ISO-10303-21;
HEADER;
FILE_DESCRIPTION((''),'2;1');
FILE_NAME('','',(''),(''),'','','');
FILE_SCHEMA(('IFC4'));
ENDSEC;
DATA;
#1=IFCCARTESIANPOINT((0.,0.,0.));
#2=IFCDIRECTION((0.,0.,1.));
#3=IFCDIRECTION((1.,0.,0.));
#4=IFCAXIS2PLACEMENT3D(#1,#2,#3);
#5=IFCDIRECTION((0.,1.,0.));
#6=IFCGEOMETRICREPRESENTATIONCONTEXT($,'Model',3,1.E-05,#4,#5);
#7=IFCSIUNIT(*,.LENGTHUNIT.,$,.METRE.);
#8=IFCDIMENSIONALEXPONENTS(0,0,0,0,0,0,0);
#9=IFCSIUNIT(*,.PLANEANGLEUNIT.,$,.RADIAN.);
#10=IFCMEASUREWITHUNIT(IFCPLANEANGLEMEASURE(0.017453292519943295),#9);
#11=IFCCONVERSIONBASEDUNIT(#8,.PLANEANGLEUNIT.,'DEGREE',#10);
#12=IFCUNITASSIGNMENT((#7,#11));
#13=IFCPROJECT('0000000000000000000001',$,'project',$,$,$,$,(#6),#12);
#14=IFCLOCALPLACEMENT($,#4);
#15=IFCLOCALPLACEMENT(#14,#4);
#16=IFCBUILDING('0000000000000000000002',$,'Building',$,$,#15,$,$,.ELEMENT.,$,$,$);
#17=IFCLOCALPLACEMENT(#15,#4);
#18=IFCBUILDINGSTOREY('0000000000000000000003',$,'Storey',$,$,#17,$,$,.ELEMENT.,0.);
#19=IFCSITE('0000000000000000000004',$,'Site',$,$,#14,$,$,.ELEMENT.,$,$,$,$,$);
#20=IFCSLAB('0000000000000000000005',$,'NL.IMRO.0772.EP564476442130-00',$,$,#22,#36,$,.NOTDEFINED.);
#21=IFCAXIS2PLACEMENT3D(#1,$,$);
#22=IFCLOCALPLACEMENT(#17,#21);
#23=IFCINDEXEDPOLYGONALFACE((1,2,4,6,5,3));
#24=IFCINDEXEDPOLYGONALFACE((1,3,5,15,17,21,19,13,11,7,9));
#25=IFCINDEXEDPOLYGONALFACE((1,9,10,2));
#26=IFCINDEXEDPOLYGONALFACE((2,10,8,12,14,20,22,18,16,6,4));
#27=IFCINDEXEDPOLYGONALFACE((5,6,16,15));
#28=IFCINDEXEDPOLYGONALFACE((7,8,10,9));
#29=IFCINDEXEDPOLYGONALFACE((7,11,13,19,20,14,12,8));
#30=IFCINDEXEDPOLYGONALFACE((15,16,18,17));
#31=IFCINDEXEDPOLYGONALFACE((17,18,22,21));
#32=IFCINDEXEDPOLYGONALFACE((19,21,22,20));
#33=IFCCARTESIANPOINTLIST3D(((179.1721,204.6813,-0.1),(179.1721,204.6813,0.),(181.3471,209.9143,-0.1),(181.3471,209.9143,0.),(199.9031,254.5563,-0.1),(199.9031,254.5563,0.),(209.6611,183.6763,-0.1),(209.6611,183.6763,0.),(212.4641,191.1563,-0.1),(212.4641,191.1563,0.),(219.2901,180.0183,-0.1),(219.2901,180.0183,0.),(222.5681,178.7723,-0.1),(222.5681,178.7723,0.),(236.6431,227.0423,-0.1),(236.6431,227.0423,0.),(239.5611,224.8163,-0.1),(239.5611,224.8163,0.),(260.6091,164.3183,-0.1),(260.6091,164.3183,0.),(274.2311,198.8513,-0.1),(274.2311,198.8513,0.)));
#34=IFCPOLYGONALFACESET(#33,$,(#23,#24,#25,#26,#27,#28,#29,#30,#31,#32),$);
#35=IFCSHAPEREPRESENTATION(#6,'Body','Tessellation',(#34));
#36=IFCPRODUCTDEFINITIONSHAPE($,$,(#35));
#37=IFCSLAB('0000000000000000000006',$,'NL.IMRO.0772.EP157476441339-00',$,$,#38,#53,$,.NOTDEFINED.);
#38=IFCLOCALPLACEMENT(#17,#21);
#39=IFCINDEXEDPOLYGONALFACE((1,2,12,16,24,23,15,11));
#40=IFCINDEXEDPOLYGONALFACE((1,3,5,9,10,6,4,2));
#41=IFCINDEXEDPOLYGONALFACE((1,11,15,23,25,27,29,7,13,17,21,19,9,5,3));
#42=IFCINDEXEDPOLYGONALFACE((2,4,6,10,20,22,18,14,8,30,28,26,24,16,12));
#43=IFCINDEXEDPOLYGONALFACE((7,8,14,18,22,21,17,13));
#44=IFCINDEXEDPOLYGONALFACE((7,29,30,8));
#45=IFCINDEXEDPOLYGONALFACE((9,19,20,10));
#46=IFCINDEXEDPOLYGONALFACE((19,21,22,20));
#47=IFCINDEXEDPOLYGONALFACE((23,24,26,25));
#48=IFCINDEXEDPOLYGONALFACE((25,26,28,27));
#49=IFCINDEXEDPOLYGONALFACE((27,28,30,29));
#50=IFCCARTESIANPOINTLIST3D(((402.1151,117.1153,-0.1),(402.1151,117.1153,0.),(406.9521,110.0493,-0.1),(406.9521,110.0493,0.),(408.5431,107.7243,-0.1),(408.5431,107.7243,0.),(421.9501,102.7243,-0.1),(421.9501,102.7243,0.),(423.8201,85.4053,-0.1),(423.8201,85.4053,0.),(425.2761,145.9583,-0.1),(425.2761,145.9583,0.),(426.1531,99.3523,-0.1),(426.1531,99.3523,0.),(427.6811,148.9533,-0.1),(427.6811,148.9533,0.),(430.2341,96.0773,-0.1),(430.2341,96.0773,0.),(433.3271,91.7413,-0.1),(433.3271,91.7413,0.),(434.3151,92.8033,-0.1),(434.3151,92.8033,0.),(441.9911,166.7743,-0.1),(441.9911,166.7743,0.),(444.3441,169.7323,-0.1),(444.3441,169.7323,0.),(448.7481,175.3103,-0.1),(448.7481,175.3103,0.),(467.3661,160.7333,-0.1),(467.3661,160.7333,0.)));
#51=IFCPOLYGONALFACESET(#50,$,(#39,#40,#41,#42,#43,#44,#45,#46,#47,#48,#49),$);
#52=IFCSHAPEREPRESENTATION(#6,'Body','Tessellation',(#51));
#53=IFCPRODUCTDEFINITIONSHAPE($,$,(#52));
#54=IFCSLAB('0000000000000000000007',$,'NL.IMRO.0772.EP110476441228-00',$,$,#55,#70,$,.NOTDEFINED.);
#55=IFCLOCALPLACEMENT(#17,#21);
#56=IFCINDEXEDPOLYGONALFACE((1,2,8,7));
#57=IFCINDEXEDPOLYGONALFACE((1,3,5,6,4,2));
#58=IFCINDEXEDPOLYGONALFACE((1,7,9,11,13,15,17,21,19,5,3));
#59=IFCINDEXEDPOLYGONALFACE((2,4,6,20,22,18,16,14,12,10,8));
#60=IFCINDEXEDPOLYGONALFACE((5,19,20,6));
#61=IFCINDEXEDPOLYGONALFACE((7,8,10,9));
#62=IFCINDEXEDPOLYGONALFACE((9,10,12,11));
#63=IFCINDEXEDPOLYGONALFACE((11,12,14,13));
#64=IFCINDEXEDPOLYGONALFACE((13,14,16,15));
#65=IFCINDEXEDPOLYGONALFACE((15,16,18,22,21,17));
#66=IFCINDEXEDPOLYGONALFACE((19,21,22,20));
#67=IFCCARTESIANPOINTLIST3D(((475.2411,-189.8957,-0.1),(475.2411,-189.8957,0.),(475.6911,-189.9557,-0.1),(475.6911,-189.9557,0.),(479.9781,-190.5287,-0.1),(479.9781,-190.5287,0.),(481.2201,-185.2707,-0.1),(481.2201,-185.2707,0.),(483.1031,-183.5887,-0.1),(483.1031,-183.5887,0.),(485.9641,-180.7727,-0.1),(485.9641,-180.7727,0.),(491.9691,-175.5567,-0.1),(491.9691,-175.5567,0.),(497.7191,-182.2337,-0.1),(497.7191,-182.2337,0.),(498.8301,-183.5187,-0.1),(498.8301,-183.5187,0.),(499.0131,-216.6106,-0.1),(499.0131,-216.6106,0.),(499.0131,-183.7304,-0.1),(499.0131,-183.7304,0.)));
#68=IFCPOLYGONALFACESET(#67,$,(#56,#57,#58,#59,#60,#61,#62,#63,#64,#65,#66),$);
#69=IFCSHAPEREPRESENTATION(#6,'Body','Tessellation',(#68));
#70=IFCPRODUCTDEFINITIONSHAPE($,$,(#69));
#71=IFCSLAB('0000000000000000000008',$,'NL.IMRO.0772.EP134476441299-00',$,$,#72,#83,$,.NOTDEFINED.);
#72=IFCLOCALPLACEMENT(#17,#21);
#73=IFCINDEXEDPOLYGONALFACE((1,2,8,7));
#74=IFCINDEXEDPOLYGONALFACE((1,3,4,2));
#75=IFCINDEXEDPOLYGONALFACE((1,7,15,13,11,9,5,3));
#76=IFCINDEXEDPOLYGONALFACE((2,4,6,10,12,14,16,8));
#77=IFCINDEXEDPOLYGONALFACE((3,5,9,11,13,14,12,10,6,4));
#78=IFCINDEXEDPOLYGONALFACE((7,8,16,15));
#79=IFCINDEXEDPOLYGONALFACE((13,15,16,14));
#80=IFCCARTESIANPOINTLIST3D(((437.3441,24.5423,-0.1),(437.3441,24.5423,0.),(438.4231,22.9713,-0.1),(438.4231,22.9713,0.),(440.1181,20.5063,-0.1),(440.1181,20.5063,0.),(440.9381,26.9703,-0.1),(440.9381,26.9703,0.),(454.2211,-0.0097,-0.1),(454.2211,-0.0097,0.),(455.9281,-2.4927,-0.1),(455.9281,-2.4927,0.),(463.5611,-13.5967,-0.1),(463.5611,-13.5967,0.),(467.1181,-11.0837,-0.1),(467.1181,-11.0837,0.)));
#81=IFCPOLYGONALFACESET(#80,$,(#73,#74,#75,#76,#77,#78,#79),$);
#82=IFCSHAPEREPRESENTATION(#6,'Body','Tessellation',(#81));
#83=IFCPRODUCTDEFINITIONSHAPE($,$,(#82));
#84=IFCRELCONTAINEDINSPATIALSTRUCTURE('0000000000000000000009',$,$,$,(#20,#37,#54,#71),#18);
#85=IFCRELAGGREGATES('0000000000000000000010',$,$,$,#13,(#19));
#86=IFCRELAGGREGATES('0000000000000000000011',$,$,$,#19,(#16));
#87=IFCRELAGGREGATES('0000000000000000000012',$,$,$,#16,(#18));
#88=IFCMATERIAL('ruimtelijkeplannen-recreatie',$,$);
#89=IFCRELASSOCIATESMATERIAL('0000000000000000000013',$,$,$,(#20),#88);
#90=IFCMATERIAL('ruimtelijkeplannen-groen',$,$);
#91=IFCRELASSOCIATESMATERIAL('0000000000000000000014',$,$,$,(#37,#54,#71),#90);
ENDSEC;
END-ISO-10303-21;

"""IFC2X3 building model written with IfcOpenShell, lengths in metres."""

from ifc_helpers import new_model, entity, si_unit, converted_unit, direction, frame, origin_with_axes, place, context, project, spatial, polyline, outline, extrude, material, element, save


model = new_model("IFC2X3")

# Units and contexts
model_context = context("Model", 3, precision=1e-05, world=origin_with_axes(), true_north=direction((0.0, 1.0, 0.0)))
ifc_project = project(units=[si_unit("LENGTHUNIT", "METRE"), converted_unit("PLANEANGLEUNIT", "DEGREE", entity("IfcPlaneAngleMeasure", 0.017453292519943295), si_unit("PLANEANGLEUNIT", "RADIAN"), dimensions=[0, 0, 0, 0, 0, 0, 0])], contexts=[model_context])

# Site, building, storey
site_placement = place(None, origin_with_axes())
site = spatial("IfcSite", under=ifc_project, at=site_placement, Name="Site", CompositionType="ELEMENT")
building_placement = place(site_placement, origin_with_axes())
building = spatial("IfcBuilding", under=site, at=building_placement, Name="Building", CompositionType="ELEMENT")
storey_placement = place(building_placement, origin_with_axes())
storey = spatial("IfcBuildingStorey", under=building, at=storey_placement, Name="Storey", CompositionType="ELEMENT", Elevation=0.0)

# Slabs
ifc_material_1 = material(Name="ruimtelijkeplannen-groen")
ifc_material_2 = material(Name="ruimtelijkeplannen-recreatie")
slab_1_placement = place(storey_placement, frame((0.0, 0.0, -0.1), z_axis=(0.0, 0.0, 1.0), x_axis=(1.0, 0.0, 0.0)))
element("IfcSlab", 1, at=slab_1_placement, inside=storey, material=ifc_material_2, Name="NL.IMRO.0772.EP564476442130-00", PredefinedType="NOTDEFINED", context=model_context, shape_type="SweptSolid", body=[
    extrude(outline(polyline([(236.6431, 227.0423), (239.5611, 224.8163), (274.2311, 198.8513), (260.6091, 164.3183), (222.5681, 178.7723), (219.2901, 180.0183), (209.6611, 183.6763), (212.4641, 191.1563), (179.1721, 204.6813), (181.3471, 209.9143), (199.9031, 254.5563), (236.6431, 227.0423)])), origin_with_axes(), (0.0, 0.0, 1.0), 0.1),
])
slab_2_placement = place(storey_placement, frame((0.0, 0.0, -0.1), z_axis=(0.0, 0.0, 1.0), x_axis=(1.0, 0.0, 0.0)))
element("IfcSlab", 2, at=slab_2_placement, inside=storey, material=ifc_material_1, Name="NL.IMRO.0772.EP157476441339-00", PredefinedType="NOTDEFINED", context=model_context, shape_type="SweptSolid", body=[
    extrude(outline(polyline([(433.3271, 91.7413), (423.8201, 85.4053), (408.5431, 107.7243), (406.9521, 110.0493), (402.1151, 117.1153), (425.2761, 145.9583), (427.6811, 148.9533), (441.9911, 166.7743), (444.3441, 169.7323), (448.7481, 175.3103), (467.3661, 160.7333), (421.9501, 102.7243), (426.1531, 99.3523), (430.2341, 96.0773), (434.3151, 92.8033), (433.3271, 91.7413)])), origin_with_axes(), (0.0, 0.0, 1.0), 0.1),
])
slab_3_placement = place(storey_placement, frame((0.0, 0.0, -0.1), z_axis=(0.0, 0.0, 1.0), x_axis=(1.0, 0.0, 0.0)))
element("IfcSlab", 3, at=slab_3_placement, inside=storey, material=ifc_material_1, Name="NL.IMRO.0772.EP110476441228-00", PredefinedType="NOTDEFINED", context=model_context, shape_type="SweptSolid", body=[
    extrude(outline(polyline([(479.9781, -190.5287), (475.6911, -189.9557), (475.2411, -189.8957), (481.2201, -185.2707), (483.1031, -183.5887), (485.9641, -180.7727), (491.9691, -175.5567), (497.7191, -182.2337), (498.8301, -183.5187), (499.0131, -183.7304), (499.0131, -216.6106), (479.9781, -190.5287)])), origin_with_axes(), (0.0, 0.0, 1.0), 0.1),
])
slab_4_placement = place(storey_placement, frame((0.0, 0.0, -0.1), z_axis=(0.0, 0.0, 1.0), x_axis=(1.0, 0.0, 0.0)))
element("IfcSlab", 4, at=slab_4_placement, inside=storey, material=ifc_material_1, Name="NL.IMRO.0772.EP134476441299-00", PredefinedType="NOTDEFINED", context=model_context, shape_type="SweptSolid", body=[
    extrude(outline(polyline([(454.2211, -0.0097), (440.1181, 20.5063), (438.4231, 22.9713), (437.3441, 24.5423), (440.9381, 26.9703), (467.1181, -11.0837), (463.5611, -13.5967), (455.9281, -2.4927), (454.2211, -0.0097)])), origin_with_axes(), (0.0, 0.0, 1.0), 0.1),
])

save(model, "model.ifc")
